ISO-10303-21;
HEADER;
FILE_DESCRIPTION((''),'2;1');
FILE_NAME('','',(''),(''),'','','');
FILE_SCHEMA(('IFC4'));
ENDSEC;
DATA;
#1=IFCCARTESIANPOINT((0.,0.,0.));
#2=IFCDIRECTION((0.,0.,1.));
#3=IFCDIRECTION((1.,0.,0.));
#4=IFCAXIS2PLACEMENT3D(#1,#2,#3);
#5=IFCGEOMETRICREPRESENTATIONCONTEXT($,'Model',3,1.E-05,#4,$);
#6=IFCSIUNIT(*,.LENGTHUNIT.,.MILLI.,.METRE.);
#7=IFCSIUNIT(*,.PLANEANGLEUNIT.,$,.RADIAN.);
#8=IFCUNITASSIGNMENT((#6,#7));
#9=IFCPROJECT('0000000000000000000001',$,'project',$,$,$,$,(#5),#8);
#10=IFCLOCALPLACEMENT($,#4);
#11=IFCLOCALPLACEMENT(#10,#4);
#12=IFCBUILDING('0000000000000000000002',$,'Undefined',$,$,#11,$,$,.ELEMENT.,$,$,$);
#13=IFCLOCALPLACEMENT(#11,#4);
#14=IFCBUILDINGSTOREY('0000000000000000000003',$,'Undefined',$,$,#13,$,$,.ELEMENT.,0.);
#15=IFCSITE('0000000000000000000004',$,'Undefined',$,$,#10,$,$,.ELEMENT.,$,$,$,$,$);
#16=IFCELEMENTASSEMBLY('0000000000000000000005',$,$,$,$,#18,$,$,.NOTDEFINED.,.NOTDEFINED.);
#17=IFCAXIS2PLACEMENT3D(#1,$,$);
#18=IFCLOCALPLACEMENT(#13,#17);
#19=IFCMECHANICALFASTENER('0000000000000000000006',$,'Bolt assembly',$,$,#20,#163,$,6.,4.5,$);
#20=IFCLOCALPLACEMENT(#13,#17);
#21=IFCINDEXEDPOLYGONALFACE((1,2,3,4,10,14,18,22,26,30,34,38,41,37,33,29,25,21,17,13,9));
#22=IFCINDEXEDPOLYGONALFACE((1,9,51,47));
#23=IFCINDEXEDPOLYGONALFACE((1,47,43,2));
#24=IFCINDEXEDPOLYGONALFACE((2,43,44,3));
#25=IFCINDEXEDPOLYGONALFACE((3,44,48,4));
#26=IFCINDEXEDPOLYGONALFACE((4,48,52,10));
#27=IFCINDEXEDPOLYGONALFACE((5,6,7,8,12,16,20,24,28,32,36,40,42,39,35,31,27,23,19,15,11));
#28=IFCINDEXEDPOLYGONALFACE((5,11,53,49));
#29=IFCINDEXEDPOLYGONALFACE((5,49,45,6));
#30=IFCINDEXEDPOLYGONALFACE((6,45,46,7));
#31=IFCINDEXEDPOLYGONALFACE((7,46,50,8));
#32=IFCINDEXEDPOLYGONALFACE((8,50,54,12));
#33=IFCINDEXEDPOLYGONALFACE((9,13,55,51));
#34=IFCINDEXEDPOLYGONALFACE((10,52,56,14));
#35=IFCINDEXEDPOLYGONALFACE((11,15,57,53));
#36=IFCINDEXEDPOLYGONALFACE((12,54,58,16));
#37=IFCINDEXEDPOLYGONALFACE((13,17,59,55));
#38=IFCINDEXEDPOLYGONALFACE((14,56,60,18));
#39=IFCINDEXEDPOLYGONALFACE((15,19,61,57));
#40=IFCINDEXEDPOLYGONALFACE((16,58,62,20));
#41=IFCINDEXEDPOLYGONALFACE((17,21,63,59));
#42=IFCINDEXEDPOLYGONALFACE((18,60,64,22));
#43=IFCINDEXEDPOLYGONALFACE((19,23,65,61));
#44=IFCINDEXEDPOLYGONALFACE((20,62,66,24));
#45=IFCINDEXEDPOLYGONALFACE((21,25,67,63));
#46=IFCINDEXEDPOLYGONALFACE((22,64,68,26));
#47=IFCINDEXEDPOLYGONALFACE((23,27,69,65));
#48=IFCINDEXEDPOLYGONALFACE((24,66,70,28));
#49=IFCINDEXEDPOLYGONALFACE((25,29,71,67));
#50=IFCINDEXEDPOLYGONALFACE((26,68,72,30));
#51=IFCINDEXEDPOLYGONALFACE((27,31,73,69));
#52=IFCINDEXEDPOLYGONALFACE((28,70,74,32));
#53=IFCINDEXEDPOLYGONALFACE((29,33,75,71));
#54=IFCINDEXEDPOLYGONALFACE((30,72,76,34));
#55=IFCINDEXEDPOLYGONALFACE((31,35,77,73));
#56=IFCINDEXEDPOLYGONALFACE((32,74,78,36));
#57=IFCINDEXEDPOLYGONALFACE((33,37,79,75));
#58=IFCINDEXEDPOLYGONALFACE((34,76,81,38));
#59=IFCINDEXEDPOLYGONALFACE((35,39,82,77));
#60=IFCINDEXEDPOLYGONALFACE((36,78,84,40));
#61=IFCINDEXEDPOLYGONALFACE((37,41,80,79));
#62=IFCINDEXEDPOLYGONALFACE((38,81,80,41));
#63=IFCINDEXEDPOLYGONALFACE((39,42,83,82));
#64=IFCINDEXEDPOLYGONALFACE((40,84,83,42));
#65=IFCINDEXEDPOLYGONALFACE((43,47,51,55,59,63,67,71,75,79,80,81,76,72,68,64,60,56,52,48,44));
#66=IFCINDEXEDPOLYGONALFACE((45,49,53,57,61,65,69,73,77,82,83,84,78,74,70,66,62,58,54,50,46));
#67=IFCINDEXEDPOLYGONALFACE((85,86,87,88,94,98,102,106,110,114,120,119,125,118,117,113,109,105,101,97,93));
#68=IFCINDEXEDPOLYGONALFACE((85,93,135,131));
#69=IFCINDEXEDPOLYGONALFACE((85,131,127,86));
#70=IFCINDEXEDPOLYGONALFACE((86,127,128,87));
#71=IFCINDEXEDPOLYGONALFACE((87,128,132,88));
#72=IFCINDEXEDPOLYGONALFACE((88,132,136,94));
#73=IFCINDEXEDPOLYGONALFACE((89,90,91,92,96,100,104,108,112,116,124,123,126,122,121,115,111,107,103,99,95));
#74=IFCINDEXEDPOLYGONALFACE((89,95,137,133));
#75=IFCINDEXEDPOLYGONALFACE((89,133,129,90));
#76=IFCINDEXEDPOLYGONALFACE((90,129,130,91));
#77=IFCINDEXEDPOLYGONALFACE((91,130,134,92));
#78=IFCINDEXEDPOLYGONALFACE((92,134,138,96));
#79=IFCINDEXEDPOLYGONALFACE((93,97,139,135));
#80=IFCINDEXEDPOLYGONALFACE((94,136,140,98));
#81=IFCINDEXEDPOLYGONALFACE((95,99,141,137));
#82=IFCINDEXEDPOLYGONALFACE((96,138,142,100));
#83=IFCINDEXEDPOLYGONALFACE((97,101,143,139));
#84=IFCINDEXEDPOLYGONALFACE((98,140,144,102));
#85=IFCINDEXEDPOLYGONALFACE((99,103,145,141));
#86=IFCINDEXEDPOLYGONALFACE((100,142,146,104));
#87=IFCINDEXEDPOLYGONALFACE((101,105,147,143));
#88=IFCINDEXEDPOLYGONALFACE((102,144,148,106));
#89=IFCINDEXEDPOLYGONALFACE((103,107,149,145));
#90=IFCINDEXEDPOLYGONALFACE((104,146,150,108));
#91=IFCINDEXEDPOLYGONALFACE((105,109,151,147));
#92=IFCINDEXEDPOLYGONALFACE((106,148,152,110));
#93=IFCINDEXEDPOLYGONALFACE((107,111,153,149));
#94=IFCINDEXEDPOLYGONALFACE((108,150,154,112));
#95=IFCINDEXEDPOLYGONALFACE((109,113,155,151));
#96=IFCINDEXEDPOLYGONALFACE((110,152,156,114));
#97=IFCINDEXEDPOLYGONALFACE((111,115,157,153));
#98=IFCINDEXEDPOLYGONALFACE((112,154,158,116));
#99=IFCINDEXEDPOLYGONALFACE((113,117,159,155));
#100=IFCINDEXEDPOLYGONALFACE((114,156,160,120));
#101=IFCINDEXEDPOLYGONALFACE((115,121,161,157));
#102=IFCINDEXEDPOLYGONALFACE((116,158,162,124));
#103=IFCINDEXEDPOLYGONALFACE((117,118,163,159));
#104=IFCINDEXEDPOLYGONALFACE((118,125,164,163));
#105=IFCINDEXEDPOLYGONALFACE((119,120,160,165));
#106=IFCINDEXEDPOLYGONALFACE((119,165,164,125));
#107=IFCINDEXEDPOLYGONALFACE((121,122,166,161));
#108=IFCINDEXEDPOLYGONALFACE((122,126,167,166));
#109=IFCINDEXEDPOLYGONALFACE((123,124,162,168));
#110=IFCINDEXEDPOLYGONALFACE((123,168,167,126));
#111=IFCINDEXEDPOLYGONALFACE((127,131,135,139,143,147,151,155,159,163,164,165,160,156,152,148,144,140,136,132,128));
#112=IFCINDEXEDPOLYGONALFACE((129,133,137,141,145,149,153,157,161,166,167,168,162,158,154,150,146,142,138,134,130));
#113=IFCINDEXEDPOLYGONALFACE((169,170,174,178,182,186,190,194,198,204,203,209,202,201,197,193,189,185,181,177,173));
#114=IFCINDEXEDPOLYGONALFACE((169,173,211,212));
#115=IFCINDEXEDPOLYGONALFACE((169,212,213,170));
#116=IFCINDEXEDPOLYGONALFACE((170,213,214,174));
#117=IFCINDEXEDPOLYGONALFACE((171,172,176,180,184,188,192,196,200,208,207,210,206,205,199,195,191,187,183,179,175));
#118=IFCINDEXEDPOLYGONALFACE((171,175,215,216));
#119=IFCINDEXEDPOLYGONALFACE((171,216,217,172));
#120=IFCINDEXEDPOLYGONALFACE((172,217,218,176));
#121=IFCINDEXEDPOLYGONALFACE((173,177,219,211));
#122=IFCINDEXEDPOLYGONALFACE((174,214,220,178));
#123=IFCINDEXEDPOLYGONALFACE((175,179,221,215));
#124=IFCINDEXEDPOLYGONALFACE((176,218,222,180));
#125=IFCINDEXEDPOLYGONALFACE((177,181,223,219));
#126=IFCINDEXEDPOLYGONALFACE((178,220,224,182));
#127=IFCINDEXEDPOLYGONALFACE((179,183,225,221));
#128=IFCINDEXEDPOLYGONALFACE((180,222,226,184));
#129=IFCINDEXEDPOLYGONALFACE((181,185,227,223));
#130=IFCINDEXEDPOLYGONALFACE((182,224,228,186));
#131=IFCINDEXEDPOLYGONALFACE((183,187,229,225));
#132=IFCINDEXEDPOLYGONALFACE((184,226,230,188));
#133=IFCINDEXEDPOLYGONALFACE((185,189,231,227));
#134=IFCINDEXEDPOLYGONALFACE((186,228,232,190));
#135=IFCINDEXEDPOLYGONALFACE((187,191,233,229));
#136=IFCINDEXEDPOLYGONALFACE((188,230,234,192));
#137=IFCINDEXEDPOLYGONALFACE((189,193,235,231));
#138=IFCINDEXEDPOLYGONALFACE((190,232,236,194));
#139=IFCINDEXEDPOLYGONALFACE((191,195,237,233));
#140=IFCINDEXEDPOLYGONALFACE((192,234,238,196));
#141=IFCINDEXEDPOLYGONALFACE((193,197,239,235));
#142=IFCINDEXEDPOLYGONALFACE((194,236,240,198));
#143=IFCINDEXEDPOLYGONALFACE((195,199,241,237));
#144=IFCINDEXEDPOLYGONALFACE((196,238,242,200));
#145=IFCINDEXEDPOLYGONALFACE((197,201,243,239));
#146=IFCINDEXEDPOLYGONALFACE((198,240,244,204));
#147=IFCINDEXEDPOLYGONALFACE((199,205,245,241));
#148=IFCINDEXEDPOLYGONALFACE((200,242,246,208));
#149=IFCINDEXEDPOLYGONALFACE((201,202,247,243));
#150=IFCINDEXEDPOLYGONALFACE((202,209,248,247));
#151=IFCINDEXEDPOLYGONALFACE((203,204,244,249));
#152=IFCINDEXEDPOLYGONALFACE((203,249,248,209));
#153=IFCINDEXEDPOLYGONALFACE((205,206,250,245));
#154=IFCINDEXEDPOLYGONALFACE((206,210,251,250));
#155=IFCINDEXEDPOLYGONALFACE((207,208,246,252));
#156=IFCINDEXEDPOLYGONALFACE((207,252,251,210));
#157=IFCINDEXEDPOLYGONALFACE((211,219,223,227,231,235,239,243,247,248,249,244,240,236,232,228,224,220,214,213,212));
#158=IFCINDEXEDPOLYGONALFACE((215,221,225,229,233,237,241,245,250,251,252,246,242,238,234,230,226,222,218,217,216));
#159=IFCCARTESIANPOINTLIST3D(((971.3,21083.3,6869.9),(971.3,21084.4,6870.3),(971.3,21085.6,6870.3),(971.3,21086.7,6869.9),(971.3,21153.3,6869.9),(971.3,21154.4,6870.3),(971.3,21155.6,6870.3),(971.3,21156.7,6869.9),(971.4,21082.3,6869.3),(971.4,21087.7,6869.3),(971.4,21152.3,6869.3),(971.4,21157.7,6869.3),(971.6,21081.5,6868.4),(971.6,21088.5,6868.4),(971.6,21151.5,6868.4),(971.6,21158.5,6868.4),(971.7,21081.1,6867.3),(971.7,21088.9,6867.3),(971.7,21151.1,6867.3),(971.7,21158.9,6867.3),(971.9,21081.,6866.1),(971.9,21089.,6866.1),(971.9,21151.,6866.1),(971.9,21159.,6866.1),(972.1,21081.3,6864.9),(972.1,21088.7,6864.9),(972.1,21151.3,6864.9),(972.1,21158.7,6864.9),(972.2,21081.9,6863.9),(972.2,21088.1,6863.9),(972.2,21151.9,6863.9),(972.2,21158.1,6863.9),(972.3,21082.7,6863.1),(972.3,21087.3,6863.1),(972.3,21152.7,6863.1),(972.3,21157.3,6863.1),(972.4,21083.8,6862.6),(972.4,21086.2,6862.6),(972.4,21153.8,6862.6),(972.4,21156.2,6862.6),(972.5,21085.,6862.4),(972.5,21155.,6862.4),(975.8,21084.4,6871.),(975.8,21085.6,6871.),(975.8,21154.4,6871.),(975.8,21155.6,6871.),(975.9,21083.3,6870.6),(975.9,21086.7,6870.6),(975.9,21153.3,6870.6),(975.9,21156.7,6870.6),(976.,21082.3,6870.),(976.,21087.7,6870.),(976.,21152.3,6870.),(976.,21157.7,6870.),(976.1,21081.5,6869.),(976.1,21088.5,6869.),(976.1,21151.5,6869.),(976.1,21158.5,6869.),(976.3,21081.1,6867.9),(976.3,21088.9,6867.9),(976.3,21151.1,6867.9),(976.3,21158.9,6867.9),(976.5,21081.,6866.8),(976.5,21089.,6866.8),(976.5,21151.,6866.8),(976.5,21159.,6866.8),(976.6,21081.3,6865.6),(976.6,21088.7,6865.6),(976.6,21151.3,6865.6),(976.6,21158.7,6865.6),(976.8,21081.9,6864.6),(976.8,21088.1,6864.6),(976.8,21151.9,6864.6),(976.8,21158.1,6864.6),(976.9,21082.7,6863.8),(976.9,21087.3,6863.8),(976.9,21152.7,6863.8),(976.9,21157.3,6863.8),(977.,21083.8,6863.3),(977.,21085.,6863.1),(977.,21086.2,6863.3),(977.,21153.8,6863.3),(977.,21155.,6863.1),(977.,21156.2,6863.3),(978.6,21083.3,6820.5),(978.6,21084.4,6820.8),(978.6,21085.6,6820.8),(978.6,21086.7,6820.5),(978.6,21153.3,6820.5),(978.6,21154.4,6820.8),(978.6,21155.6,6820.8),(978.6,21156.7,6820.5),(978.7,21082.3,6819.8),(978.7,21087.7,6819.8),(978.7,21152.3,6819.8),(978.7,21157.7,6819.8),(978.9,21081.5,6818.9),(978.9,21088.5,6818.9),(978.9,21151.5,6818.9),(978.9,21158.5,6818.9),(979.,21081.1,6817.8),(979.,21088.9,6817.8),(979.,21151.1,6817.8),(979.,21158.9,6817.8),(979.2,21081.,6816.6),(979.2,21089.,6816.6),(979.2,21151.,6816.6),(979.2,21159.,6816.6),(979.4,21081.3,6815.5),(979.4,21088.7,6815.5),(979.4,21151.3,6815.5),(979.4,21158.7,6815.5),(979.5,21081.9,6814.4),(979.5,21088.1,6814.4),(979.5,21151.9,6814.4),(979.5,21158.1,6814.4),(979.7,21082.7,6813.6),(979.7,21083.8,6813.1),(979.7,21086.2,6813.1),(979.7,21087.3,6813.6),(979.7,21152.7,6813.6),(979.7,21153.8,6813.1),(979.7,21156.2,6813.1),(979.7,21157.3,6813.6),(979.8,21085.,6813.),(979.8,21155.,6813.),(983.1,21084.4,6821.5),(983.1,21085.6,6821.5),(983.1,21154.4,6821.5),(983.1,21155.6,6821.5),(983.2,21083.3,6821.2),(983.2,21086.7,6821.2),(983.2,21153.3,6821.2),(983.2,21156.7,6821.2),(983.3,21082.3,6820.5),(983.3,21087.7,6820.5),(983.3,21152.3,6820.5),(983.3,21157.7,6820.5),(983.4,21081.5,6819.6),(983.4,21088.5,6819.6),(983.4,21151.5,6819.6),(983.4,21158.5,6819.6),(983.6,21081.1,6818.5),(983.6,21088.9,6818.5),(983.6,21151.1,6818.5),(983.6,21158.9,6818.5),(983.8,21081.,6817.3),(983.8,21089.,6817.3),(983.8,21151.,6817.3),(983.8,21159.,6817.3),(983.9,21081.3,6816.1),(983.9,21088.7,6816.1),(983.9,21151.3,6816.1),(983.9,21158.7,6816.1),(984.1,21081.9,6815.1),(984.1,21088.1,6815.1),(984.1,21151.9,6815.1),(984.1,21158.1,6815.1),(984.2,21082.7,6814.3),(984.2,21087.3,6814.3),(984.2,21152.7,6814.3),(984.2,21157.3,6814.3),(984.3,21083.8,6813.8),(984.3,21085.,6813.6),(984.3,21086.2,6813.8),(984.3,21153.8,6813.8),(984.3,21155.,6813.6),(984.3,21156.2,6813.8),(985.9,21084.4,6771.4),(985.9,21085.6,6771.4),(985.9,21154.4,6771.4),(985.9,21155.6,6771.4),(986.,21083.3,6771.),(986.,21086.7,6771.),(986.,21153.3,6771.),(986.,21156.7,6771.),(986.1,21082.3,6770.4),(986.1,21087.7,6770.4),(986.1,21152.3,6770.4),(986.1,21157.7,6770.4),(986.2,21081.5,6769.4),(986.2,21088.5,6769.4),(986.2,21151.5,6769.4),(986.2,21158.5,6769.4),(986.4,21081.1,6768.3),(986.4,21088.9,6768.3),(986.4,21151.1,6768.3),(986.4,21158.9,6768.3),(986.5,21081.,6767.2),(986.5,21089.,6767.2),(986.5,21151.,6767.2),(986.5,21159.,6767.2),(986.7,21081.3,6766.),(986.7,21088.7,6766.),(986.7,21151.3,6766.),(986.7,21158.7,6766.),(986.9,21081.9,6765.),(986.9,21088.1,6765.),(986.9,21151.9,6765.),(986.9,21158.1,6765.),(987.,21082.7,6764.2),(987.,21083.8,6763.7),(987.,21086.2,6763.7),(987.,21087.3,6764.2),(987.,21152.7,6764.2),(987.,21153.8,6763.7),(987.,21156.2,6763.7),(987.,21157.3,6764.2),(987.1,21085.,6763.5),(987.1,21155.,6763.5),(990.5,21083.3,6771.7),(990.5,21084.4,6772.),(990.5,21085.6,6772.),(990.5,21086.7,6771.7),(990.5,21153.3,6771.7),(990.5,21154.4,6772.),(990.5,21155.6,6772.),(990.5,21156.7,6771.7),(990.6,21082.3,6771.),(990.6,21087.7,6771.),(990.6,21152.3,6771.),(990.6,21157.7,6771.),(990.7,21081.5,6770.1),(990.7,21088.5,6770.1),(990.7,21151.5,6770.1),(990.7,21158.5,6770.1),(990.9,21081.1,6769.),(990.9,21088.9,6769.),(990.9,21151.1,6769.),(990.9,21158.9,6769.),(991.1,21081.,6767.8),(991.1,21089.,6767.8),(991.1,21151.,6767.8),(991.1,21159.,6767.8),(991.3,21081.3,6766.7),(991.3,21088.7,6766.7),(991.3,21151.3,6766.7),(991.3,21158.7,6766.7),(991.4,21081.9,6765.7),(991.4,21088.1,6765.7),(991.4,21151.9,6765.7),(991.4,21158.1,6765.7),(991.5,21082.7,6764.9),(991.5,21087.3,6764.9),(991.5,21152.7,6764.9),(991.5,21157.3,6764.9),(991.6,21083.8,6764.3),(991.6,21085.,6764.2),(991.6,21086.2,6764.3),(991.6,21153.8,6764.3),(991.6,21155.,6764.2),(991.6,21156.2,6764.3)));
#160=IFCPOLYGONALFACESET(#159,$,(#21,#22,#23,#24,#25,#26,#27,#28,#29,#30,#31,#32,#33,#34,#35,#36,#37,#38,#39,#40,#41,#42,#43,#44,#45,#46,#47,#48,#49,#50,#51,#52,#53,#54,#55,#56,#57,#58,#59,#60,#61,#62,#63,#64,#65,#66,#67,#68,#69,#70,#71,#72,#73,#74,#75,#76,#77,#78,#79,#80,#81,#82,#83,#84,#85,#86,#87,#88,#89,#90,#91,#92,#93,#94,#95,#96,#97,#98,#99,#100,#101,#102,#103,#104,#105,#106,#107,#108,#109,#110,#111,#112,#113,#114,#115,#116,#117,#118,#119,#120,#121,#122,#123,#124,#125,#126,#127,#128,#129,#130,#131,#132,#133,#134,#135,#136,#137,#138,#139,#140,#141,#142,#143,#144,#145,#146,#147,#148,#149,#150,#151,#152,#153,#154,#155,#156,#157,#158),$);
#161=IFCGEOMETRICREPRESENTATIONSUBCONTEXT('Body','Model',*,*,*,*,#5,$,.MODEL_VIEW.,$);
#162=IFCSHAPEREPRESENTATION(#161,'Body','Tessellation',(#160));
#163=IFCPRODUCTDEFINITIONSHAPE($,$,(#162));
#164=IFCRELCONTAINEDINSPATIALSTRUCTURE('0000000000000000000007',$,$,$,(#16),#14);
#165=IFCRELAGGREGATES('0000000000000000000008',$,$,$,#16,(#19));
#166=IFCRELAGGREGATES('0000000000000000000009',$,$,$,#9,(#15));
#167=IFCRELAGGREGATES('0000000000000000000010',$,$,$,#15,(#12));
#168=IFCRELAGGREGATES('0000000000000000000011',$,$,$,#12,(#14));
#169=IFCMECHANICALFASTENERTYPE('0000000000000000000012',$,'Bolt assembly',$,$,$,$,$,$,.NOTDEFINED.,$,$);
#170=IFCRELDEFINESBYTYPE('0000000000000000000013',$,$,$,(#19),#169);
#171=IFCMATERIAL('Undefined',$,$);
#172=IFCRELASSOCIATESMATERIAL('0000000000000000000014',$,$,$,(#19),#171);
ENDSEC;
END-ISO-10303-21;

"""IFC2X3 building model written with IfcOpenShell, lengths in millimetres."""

from ifc_helpers import new_model, si_unit, frame, origin_with_axes, origin_2d_with_axis, place, context, subcontext, project, spatial, circle, extrude, source, transform, mapped, material, type_object, element, aggregate, save


model = new_model("IFC2X3")

# Units and contexts
model_context = context("Model", 3, precision=1e-05, world=origin_with_axes())
body_context = subcontext(model_context, "Body", "Model", "MODEL_VIEW")
ifc_project = project(units=[si_unit("LENGTHUNIT", "METRE", prefix="MILLI"), si_unit("PLANEANGLEUNIT", "RADIAN")], contexts=[model_context])

# Site, building, storey
site_placement = place(None, origin_with_axes())
site = spatial("IfcSite", under=ifc_project, at=site_placement, Name="Undefined", CompositionType="ELEMENT")
building_placement = place(site_placement, origin_with_axes())
building = spatial("IfcBuilding", under=site, at=building_placement, Name="Undefined", CompositionType="ELEMENT")
storey_placement = place(building_placement, origin_with_axes())
storey = spatial("IfcBuildingStorey", under=building, at=storey_placement, Name="Undefined", CompositionType="ELEMENT", Elevation=0.0)

# Element assembly
assembly_1_placement = place(storey_placement, origin_with_axes())
assembly_1 = element("IfcElementAssembly", 1, at=assembly_1_placement, inside=storey, AssemblyPlace="NOTDEFINED", PredefinedType="NOTDEFINED")

# Mechanical fastener
ifc_material_1 = material(Name="Undefined")
mechanical_fastener_type = type_object("IfcMechanicalFastenerType", Name="Bolt assembly")
shared_shape_1 = source(origin_with_axes(), body_context, "Body", "SweptSolid", [
    extrude(circle(Radius=4.0, at=origin_2d_with_axis()), frame((0.0, 0.0, 0.0), z_axis=(0.0, 1.0, 0.0), x_axis=(1.0, 0.0, 0.0)), (0.0, 0.0, 1.0), 4.6),
])
mechanical_fastener_1_placement = place(assembly_1_placement, frame((971.9, 21120.0, 6866.4), z_axis=(0.0, -1.0, 0.0), x_axis=(0.146203, 0.0, -0.989255)))
mechanical_fastener_1 = element("IfcMechanicalFastener", 2, at=mechanical_fastener_1_placement, type_object=mechanical_fastener_type, material=ifc_material_1, Name="Bolt assembly", NominalDiameter=6.0, NominalLength=4.5, context=body_context, shape_type="MappedRepresentation", body=[
    mapped(shared_shape_1, transform((0.0, 0.0, -35.0))),
    mapped(shared_shape_1, transform((50.0, 0.0, -35.0))),
    mapped(shared_shape_1, transform((100.0, 0.0, -35.0))),
    mapped(shared_shape_1, transform((0.0, 0.0, 35.0))),
    mapped(shared_shape_1, transform((50.0, 0.0, 35.0))),
    mapped(shared_shape_1, transform((100.0, 0.0, 35.0))),
])

aggregate(assembly_1, [mechanical_fastener_1])

save(model, "model.ifc")
